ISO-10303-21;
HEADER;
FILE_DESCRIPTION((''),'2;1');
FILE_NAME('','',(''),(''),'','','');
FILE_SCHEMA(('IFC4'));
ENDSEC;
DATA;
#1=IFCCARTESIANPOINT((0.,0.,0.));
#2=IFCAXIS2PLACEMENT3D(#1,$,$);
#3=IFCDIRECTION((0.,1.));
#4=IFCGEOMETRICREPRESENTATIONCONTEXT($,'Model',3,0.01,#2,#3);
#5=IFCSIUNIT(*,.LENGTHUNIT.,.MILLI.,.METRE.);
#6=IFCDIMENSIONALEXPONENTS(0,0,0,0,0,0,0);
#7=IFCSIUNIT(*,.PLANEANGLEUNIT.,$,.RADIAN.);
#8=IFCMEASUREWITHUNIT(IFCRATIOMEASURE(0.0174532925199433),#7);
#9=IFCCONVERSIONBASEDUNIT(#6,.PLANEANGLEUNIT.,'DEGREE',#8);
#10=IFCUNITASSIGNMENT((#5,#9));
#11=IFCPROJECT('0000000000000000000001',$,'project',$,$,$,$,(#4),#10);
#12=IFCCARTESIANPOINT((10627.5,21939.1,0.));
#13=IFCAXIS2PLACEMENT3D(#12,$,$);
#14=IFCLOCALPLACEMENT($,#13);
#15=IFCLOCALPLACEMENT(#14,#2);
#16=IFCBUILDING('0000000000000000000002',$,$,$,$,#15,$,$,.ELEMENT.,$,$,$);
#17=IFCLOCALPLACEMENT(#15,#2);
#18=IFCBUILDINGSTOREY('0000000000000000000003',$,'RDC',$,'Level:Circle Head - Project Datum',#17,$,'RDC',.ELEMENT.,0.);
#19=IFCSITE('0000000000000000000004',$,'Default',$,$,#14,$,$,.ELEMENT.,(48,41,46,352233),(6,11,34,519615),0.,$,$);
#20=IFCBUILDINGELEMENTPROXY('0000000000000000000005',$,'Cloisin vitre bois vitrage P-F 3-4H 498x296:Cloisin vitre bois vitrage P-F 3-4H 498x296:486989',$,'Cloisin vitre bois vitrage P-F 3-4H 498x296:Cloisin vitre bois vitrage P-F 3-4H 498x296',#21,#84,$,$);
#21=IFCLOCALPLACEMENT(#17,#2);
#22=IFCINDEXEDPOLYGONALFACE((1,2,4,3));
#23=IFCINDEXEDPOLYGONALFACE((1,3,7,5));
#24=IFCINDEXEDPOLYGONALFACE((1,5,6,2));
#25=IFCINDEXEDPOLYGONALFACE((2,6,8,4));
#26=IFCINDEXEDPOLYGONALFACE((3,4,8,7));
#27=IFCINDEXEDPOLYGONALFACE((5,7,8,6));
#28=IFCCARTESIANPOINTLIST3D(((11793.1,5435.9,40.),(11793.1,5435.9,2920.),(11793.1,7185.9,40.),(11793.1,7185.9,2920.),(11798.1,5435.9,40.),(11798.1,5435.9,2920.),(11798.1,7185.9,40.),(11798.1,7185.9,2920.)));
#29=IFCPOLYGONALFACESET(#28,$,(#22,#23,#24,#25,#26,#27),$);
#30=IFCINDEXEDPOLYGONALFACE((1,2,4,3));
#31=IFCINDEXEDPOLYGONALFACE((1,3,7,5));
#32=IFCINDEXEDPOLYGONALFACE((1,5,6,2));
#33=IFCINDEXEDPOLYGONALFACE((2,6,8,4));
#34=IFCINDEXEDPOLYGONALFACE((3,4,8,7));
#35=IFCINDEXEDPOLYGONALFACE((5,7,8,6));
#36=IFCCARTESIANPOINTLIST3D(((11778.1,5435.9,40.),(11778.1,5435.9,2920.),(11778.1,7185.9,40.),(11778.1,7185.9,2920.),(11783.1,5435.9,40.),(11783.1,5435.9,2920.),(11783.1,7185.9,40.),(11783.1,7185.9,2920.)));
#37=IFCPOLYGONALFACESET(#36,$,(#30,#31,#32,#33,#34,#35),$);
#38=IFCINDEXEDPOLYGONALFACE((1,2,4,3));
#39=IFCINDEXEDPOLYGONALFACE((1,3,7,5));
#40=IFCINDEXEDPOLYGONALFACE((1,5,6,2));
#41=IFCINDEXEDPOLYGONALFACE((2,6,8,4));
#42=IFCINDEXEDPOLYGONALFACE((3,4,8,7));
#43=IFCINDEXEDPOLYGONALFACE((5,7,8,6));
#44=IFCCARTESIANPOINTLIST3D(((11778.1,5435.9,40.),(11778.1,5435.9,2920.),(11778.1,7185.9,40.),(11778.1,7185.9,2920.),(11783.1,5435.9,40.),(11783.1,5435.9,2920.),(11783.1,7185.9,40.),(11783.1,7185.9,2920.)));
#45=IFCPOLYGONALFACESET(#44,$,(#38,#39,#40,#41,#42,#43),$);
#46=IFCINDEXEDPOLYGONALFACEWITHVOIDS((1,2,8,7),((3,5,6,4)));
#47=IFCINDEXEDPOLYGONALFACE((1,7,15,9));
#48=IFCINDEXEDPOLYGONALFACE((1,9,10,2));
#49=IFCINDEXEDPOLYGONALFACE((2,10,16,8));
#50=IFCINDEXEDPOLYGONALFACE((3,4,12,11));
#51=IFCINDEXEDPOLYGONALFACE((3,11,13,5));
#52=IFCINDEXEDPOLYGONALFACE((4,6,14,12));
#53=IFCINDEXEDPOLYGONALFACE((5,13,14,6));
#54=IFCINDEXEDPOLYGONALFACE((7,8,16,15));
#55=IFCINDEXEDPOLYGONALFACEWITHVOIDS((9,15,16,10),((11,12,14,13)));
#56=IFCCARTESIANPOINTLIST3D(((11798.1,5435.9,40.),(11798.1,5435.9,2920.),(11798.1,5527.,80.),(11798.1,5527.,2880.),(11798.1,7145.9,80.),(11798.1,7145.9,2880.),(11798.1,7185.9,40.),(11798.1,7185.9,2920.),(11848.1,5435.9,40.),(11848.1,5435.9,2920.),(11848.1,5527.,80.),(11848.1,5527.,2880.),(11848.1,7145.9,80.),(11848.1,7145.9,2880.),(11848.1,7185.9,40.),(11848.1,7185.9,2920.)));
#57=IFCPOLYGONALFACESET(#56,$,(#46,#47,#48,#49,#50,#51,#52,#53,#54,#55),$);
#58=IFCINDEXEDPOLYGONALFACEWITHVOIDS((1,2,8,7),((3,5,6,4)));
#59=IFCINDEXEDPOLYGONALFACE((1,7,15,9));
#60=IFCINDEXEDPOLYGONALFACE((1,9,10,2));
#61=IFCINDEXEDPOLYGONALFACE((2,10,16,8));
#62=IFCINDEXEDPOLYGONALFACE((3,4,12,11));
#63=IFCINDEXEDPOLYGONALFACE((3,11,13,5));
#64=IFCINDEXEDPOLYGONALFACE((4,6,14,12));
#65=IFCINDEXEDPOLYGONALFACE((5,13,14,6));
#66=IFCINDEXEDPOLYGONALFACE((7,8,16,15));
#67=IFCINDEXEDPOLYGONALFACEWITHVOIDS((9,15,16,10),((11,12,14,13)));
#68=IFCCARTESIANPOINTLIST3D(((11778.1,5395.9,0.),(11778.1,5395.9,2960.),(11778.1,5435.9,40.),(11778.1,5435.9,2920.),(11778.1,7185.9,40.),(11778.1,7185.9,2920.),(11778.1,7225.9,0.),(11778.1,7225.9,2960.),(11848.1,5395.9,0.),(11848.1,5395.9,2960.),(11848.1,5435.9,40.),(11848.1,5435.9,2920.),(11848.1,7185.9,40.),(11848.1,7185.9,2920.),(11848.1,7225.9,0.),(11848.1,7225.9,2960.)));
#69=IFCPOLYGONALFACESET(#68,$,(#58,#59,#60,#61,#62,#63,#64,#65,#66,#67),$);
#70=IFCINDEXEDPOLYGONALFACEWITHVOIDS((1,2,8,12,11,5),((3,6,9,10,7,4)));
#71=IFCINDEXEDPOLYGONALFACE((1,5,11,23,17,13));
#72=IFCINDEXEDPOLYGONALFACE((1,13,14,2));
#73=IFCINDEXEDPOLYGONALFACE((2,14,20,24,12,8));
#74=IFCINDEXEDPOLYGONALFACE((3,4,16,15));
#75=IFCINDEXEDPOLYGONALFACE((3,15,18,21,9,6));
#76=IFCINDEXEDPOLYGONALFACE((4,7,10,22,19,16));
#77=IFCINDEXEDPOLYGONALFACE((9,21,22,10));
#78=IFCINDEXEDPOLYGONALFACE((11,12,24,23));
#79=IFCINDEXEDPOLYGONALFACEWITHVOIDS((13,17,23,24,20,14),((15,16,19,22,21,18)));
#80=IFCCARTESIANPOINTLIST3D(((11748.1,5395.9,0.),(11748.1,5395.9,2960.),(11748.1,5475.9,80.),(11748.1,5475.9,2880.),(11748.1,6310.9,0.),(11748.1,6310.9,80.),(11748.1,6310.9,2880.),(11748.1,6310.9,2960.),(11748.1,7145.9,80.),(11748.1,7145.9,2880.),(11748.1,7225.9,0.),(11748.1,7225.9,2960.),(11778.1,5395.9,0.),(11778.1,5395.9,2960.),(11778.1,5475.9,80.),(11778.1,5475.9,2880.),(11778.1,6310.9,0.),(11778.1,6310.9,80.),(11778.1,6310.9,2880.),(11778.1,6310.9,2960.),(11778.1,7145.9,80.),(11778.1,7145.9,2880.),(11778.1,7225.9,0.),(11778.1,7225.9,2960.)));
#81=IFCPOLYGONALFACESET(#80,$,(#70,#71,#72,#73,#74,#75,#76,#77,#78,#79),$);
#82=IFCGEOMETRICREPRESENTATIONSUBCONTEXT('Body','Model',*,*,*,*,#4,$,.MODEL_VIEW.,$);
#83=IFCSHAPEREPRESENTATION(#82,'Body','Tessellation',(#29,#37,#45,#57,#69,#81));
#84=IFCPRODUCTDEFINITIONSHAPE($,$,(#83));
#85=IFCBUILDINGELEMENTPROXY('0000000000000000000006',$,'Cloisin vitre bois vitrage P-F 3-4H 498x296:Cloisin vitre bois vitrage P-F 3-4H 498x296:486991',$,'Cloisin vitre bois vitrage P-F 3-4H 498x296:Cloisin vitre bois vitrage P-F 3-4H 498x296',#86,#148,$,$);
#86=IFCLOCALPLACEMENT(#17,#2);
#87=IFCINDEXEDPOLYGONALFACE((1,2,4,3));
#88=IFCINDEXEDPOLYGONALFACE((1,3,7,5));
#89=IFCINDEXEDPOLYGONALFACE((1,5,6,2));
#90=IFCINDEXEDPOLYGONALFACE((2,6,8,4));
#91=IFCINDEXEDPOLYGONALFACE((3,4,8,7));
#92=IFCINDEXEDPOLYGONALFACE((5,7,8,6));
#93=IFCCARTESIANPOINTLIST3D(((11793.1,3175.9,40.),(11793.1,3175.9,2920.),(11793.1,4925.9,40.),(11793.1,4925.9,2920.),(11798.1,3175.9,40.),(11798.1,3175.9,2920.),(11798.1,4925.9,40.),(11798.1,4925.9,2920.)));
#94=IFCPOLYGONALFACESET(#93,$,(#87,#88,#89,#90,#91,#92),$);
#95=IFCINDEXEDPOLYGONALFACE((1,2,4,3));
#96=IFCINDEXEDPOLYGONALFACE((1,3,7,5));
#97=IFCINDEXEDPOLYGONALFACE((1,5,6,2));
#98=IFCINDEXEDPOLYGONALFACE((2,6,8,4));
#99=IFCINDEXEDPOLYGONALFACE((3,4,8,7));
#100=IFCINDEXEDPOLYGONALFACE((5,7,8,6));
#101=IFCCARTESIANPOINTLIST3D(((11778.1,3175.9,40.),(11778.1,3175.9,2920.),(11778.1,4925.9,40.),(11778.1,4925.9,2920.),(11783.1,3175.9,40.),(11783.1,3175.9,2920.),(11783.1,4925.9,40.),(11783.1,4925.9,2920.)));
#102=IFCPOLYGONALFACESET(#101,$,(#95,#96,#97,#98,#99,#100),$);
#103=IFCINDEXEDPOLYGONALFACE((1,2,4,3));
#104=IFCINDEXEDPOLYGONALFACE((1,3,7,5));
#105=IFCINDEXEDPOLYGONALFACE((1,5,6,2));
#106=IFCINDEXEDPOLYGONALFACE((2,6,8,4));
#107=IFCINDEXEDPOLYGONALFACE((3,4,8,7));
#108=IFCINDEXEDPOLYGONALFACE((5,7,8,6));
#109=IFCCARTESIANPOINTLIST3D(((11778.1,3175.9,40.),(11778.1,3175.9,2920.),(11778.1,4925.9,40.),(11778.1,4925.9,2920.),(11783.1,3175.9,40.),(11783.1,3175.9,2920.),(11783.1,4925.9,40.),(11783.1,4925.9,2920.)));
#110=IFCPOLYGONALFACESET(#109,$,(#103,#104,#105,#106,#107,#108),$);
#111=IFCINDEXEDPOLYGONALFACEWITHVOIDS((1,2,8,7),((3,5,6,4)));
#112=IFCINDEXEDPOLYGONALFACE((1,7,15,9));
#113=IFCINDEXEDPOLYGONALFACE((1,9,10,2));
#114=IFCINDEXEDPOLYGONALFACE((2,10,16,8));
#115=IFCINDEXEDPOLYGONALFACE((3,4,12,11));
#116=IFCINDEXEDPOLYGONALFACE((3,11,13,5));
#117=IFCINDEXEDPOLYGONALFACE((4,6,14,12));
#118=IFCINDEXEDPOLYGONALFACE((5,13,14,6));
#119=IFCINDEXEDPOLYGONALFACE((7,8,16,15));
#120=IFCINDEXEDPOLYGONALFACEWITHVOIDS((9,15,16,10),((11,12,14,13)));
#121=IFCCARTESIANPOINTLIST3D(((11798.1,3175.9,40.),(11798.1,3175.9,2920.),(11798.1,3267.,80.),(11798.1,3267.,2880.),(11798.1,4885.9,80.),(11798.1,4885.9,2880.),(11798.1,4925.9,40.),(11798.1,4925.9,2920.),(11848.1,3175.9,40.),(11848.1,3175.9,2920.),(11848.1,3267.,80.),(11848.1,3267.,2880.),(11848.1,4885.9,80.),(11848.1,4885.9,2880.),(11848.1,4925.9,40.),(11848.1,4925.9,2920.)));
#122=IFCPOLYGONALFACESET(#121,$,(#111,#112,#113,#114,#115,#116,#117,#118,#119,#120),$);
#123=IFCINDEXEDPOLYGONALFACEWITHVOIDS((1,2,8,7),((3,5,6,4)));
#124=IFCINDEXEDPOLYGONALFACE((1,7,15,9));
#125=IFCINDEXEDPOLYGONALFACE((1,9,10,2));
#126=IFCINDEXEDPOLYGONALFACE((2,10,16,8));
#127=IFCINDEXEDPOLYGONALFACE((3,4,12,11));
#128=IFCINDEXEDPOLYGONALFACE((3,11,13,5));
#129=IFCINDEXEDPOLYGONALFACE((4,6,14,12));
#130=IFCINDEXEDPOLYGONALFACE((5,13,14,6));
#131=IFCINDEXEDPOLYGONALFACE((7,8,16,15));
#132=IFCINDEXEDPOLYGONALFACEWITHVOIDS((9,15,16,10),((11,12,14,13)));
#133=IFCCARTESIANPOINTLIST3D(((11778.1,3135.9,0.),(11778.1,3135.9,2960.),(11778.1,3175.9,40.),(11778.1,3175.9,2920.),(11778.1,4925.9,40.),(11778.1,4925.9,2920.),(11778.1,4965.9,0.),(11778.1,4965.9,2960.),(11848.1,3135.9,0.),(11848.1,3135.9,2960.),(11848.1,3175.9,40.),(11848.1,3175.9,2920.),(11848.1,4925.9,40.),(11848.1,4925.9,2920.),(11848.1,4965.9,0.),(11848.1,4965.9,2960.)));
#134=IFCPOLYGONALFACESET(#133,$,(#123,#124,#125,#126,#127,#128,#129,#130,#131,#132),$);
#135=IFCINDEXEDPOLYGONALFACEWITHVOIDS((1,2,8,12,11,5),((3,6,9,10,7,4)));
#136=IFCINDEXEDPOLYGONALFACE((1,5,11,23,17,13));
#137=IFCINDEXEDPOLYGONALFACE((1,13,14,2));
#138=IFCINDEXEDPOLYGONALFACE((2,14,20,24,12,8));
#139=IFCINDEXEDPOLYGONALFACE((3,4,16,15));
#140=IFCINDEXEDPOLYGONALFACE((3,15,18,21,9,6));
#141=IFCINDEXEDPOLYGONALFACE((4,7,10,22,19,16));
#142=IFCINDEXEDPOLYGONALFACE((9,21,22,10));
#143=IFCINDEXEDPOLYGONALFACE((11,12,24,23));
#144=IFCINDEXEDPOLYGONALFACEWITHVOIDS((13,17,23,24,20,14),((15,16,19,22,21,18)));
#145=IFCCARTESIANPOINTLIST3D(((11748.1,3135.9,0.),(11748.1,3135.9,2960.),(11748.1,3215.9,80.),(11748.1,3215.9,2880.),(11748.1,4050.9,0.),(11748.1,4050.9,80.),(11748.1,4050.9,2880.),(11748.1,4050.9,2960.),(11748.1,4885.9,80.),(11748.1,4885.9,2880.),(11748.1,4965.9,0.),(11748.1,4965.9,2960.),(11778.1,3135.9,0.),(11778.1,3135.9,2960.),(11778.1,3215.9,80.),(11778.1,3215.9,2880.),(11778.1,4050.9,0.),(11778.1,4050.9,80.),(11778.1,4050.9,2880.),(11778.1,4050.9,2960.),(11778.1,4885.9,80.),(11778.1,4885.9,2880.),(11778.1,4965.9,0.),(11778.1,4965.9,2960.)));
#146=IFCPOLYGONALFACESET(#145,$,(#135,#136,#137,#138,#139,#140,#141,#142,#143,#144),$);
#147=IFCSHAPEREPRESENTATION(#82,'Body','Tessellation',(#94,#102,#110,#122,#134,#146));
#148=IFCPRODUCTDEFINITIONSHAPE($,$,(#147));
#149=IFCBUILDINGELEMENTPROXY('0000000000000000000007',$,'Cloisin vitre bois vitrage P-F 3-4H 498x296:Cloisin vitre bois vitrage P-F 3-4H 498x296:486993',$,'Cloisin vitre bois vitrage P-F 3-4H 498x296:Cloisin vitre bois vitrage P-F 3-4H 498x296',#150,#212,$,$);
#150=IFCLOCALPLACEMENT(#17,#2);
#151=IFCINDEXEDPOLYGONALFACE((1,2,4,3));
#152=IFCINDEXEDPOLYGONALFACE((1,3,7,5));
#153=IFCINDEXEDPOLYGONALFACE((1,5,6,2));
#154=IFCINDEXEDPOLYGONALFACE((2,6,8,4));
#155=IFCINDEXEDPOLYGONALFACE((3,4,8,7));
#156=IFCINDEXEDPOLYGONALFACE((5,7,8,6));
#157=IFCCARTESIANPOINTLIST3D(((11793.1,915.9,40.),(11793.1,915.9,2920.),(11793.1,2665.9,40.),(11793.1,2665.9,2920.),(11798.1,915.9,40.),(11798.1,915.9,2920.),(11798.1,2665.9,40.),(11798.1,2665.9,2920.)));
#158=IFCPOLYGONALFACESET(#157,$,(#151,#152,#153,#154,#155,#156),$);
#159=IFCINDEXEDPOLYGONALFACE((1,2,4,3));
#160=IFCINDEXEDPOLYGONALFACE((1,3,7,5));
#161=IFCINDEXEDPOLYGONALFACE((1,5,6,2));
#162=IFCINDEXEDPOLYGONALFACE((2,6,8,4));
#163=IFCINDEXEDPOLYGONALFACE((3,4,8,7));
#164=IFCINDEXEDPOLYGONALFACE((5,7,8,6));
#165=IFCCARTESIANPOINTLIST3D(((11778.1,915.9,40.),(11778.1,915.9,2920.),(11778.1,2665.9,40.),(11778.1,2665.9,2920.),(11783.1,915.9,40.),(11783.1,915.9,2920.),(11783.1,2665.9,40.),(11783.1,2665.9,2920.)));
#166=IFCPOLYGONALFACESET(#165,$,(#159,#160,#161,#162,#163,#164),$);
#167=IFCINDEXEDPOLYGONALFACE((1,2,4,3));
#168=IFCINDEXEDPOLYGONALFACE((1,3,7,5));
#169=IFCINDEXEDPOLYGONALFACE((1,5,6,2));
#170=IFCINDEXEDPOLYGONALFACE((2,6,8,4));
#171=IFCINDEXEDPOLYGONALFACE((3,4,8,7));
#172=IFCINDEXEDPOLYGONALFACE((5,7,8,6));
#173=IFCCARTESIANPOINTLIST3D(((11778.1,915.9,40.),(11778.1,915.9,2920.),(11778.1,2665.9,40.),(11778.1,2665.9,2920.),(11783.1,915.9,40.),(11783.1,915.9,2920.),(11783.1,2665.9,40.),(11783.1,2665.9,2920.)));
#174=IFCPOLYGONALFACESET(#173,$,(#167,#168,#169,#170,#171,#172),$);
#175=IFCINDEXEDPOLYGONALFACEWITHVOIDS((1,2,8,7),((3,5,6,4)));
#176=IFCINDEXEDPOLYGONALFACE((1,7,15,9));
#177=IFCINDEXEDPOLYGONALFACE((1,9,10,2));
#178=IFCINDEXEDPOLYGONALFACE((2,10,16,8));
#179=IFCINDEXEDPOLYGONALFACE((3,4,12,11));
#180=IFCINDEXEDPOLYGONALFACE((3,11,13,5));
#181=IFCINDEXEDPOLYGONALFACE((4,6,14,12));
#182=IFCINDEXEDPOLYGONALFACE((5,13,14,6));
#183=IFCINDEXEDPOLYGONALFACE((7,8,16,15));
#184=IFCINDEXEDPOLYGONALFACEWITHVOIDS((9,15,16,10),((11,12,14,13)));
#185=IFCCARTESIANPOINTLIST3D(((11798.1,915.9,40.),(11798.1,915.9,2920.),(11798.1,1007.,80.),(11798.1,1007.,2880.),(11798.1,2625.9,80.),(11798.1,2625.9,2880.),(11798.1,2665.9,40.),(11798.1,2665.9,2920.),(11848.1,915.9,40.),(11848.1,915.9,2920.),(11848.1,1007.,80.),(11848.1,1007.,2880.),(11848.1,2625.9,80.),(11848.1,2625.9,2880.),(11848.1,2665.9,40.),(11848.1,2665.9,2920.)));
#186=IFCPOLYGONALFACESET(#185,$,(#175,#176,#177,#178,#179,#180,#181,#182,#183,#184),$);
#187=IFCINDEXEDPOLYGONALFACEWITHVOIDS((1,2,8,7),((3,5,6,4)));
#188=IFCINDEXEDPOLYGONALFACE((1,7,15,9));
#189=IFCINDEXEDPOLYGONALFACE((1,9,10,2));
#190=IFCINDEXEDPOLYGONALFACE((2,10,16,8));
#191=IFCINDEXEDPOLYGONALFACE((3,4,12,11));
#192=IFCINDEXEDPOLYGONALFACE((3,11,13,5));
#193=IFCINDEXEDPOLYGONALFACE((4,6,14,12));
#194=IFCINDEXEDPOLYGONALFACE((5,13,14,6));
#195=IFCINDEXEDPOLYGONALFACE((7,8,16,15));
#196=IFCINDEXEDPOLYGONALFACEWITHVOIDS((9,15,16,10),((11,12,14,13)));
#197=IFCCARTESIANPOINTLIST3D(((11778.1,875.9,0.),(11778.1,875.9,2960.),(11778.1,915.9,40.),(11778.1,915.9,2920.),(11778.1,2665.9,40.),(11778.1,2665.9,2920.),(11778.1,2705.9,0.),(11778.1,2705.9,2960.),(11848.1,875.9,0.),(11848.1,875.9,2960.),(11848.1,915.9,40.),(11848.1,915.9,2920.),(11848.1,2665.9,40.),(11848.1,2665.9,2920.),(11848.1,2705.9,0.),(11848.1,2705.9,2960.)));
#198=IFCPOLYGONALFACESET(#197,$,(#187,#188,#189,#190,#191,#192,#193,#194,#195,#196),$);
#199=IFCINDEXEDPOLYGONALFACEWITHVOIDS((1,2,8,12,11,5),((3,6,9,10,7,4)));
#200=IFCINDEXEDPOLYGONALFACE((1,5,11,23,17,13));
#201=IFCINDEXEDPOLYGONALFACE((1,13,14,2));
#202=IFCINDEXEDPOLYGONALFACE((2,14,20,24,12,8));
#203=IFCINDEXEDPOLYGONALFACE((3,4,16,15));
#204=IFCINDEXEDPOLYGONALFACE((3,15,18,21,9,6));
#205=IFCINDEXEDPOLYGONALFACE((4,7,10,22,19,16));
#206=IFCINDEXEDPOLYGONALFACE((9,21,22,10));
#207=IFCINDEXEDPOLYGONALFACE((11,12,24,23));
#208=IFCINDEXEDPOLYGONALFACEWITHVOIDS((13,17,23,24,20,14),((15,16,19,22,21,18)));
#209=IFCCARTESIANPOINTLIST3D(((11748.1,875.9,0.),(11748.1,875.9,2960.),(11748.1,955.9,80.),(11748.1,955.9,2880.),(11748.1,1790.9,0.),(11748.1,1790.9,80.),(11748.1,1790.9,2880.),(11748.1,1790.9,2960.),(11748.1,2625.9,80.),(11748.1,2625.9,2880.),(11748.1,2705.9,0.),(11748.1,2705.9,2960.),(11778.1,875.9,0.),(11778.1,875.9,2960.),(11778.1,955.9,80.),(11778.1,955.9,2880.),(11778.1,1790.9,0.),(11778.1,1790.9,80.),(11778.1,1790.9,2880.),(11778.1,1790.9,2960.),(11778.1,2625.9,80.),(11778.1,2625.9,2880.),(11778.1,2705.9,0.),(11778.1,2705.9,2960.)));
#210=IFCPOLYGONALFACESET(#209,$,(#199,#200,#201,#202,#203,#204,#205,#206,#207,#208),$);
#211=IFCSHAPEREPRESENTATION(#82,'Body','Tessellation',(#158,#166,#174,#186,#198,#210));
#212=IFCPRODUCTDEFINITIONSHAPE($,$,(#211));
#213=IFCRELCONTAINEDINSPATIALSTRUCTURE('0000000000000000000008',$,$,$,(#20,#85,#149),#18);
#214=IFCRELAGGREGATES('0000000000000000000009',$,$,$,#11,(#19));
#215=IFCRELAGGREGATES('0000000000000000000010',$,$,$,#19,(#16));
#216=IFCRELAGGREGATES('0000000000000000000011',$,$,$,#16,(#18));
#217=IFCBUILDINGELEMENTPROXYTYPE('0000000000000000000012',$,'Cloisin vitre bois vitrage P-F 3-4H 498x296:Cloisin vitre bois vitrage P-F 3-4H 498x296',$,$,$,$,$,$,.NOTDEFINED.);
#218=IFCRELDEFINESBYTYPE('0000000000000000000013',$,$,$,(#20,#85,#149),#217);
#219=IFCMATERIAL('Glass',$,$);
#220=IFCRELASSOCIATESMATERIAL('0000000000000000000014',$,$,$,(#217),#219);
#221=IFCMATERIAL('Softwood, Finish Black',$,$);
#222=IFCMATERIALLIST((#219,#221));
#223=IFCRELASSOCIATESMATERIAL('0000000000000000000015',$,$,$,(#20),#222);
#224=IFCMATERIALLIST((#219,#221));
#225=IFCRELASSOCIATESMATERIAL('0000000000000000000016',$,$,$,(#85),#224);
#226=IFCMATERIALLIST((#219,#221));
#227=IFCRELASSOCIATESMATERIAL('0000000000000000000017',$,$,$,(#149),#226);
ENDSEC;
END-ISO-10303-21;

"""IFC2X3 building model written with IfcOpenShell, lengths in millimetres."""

from ifc_helpers import new_model, entity, si_unit, converted_unit, direction, frame, frame_2d, origin, place, context, subcontext, project, spatial, polyline, rectangle, outline, extrude, source, transform, mapped, material, material_list, type_object, type_shapes, element, save


model = new_model("IFC2X3")

# Units and contexts
model_context = context("Model", 3, precision=0.01, world=origin(), true_north=direction((0.0, 1.0)))
body_context = subcontext(model_context, "Body", "Model", "MODEL_VIEW")
ifc_project = project(units=[si_unit("LENGTHUNIT", "METRE", prefix="MILLI"), converted_unit("PLANEANGLEUNIT", "DEGREE", entity("IfcRatioMeasure", 0.0174532925199433), si_unit("PLANEANGLEUNIT", "RADIAN"), dimensions=[0, 0, 0, 0, 0, 0, 0])], contexts=[model_context])

# Site, building, storey
site_placement = place(None, frame((10627.5, 21939.1, 0.0)))
site = spatial("IfcSite", under=ifc_project, at=site_placement, Name="Default", CompositionType="ELEMENT", RefLatitude=(48, 41, 46, 352233), RefLongitude=(6, 11, 34, 519615), RefElevation=0.0)
building_placement = place(site_placement, origin())
building = spatial("IfcBuilding", under=site, at=building_placement, CompositionType="ELEMENT")
storey_placement = place(building_placement, origin())
storey = spatial("IfcBuildingStorey", under=building, at=storey_placement, Name="RDC", ObjectType="Level:Circle Head - Project Datum", LongName="RDC", CompositionType="ELEMENT", Elevation=0.0)

# Building element proxies
ifc_material_1 = material(Name="Glass")
ifc_material_2 = material(Name="Softwood, Finish Black")
building_element_proxy_type_1 = type_object("IfcBuildingElementProxyType", Name="Cloisin vitre bois vitrage P-F 3-4H 498x296:Cloisin vitre bois vitrage P-F 3-4H 498x296", PredefinedType="NOTDEFINED", material=ifc_material_1)
shared_shape_1 = source(origin(), body_context, "Body", "SweptSolid", [
    extrude(rectangle(XDim=1750.0, YDim=5.0, at=frame_2d((0.0, 0.0), x_axis=(1.0, 0.0))), frame((0.0, 47.5, 40.0), z_axis=(0.0, 0.0, 1.0), x_axis=(-1.0, 0.0, 0.0)), (0.0, 0.0, 1.0), 2880.0),
    extrude(rectangle(XDim=1750.0, YDim=5.0, at=frame_2d((0.0, 0.0), x_axis=(1.0, 0.0))), frame((0.0, 32.5, 40.0), z_axis=(0.0, 0.0, 1.0), x_axis=(-1.0, 0.0, 0.0)), (0.0, 0.0, 1.0), 2880.0),
    extrude(rectangle(XDim=1750.0, YDim=5.0, at=frame_2d((0.0, 0.0), x_axis=(1.0, 0.0))), frame((0.0, 32.5, 40.0), z_axis=(0.0, 0.0, 1.0), x_axis=(-1.0, 0.0, 0.0)), (0.0, 0.0, 1.0), 2880.0),
    extrude(outline(polyline([(-1440.0, -875.0), (1440.0, -875.0), (1440.0, 875.0), (-1440.0, 875.0), (-1440.0, -875.0)]), holes=[polyline([(1400.0, 835.0), (1400.0, -783.9), (-1400.0, -783.9), (-1400.0, 835.0), (1400.0, 835.0)])]), frame((0.0, 50.0, 1480.0), z_axis=(0.0, 1.0, 0.0), x_axis=(0.0, 0.0, -1.0)), (0.0, 0.0, 1.0), 50.0),
    extrude(outline(polyline([(-1480.0, -915.0), (1480.0, -915.0), (1480.0, 915.0), (-1480.0, 915.0), (-1480.0, -915.0)]), holes=[polyline([(-1440.0, -875.0), (-1440.0, 875.0), (1440.0, 875.0), (1440.0, -875.0), (-1440.0, -875.0)])]), frame((0.0, 30.0, 1480.0), z_axis=(0.0, 1.0, 0.0), x_axis=(0.0, 0.0, -1.0)), (0.0, 0.0, 1.0), 70.0),
    extrude(outline(polyline([(-1480.0, -915.0), (1480.0, -915.0), (1480.0, 0.0), (1480.0, 915.0), (-1480.0, 915.0), (-1480.0, 0.0), (-1480.0, -915.0)]), holes=[polyline([(1400.0, 0.0), (1400.0, -835.0), (-1400.0, -835.0), (-1400.0, 0.0), (-1400.0, 835.0), (1400.0, 835.0), (1400.0, 0.0)])]), frame((0.0, 0.0, 1480.0), z_axis=(0.0, 1.0, 0.0), x_axis=(0.0, 0.0, 1.0)), (0.0, 0.0, 1.0), 30.0),
])
type_shapes(building_element_proxy_type_1, [shared_shape_1])
ifc_material_list_1 = material_list([ifc_material_1, ifc_material_2])
proxy_1_placement = place(storey_placement, frame((11748.1, 6310.9, 0.0), z_axis=(0.0, 0.0, 1.0), x_axis=(0.0, -1.0, 0.0)))
element("IfcBuildingElementProxy", 1, at=proxy_1_placement, inside=storey, type_object=building_element_proxy_type_1, material=ifc_material_list_1, Name="Cloisin vitre bois vitrage P-F 3-4H 498x296:Cloisin vitre bois vitrage P-F 3-4H 498x296:486989", ObjectType="Cloisin vitre bois vitrage P-F 3-4H 498x296:Cloisin vitre bois vitrage P-F 3-4H 498x296", context=body_context, shape_type="MappedRepresentation", body=[
    mapped(shared_shape_1, transform((0.0, 0.0, 0.0), scale=1.0)),
])
ifc_material_list_2 = material_list([ifc_material_1, ifc_material_2])
proxy_2_placement = place(storey_placement, frame((11748.1, 4050.9, 0.0), z_axis=(0.0, 0.0, 1.0), x_axis=(0.0, -1.0, 0.0)))
element("IfcBuildingElementProxy", 2, at=proxy_2_placement, inside=storey, type_object=building_element_proxy_type_1, material=ifc_material_list_2, Name="Cloisin vitre bois vitrage P-F 3-4H 498x296:Cloisin vitre bois vitrage P-F 3-4H 498x296:486991", ObjectType="Cloisin vitre bois vitrage P-F 3-4H 498x296:Cloisin vitre bois vitrage P-F 3-4H 498x296", context=body_context, shape_type="MappedRepresentation", body=[
    mapped(shared_shape_1, transform((0.0, 0.0, 0.0), scale=1.0)),
])
ifc_material_list_3 = material_list([ifc_material_1, ifc_material_2])
proxy_3_placement = place(storey_placement, frame((11748.1, 1790.9, 0.0), z_axis=(0.0, 0.0, 1.0), x_axis=(0.0, -1.0, 0.0)))
element("IfcBuildingElementProxy", 3, at=proxy_3_placement, inside=storey, type_object=building_element_proxy_type_1, material=ifc_material_list_3, Name="Cloisin vitre bois vitrage P-F 3-4H 498x296:Cloisin vitre bois vitrage P-F 3-4H 498x296:486993", ObjectType="Cloisin vitre bois vitrage P-F 3-4H 498x296:Cloisin vitre bois vitrage P-F 3-4H 498x296", context=body_context, shape_type="MappedRepresentation", body=[
    mapped(shared_shape_1, transform((0.0, 0.0, 0.0), scale=1.0)),
])

save(model, "model.ifc")
